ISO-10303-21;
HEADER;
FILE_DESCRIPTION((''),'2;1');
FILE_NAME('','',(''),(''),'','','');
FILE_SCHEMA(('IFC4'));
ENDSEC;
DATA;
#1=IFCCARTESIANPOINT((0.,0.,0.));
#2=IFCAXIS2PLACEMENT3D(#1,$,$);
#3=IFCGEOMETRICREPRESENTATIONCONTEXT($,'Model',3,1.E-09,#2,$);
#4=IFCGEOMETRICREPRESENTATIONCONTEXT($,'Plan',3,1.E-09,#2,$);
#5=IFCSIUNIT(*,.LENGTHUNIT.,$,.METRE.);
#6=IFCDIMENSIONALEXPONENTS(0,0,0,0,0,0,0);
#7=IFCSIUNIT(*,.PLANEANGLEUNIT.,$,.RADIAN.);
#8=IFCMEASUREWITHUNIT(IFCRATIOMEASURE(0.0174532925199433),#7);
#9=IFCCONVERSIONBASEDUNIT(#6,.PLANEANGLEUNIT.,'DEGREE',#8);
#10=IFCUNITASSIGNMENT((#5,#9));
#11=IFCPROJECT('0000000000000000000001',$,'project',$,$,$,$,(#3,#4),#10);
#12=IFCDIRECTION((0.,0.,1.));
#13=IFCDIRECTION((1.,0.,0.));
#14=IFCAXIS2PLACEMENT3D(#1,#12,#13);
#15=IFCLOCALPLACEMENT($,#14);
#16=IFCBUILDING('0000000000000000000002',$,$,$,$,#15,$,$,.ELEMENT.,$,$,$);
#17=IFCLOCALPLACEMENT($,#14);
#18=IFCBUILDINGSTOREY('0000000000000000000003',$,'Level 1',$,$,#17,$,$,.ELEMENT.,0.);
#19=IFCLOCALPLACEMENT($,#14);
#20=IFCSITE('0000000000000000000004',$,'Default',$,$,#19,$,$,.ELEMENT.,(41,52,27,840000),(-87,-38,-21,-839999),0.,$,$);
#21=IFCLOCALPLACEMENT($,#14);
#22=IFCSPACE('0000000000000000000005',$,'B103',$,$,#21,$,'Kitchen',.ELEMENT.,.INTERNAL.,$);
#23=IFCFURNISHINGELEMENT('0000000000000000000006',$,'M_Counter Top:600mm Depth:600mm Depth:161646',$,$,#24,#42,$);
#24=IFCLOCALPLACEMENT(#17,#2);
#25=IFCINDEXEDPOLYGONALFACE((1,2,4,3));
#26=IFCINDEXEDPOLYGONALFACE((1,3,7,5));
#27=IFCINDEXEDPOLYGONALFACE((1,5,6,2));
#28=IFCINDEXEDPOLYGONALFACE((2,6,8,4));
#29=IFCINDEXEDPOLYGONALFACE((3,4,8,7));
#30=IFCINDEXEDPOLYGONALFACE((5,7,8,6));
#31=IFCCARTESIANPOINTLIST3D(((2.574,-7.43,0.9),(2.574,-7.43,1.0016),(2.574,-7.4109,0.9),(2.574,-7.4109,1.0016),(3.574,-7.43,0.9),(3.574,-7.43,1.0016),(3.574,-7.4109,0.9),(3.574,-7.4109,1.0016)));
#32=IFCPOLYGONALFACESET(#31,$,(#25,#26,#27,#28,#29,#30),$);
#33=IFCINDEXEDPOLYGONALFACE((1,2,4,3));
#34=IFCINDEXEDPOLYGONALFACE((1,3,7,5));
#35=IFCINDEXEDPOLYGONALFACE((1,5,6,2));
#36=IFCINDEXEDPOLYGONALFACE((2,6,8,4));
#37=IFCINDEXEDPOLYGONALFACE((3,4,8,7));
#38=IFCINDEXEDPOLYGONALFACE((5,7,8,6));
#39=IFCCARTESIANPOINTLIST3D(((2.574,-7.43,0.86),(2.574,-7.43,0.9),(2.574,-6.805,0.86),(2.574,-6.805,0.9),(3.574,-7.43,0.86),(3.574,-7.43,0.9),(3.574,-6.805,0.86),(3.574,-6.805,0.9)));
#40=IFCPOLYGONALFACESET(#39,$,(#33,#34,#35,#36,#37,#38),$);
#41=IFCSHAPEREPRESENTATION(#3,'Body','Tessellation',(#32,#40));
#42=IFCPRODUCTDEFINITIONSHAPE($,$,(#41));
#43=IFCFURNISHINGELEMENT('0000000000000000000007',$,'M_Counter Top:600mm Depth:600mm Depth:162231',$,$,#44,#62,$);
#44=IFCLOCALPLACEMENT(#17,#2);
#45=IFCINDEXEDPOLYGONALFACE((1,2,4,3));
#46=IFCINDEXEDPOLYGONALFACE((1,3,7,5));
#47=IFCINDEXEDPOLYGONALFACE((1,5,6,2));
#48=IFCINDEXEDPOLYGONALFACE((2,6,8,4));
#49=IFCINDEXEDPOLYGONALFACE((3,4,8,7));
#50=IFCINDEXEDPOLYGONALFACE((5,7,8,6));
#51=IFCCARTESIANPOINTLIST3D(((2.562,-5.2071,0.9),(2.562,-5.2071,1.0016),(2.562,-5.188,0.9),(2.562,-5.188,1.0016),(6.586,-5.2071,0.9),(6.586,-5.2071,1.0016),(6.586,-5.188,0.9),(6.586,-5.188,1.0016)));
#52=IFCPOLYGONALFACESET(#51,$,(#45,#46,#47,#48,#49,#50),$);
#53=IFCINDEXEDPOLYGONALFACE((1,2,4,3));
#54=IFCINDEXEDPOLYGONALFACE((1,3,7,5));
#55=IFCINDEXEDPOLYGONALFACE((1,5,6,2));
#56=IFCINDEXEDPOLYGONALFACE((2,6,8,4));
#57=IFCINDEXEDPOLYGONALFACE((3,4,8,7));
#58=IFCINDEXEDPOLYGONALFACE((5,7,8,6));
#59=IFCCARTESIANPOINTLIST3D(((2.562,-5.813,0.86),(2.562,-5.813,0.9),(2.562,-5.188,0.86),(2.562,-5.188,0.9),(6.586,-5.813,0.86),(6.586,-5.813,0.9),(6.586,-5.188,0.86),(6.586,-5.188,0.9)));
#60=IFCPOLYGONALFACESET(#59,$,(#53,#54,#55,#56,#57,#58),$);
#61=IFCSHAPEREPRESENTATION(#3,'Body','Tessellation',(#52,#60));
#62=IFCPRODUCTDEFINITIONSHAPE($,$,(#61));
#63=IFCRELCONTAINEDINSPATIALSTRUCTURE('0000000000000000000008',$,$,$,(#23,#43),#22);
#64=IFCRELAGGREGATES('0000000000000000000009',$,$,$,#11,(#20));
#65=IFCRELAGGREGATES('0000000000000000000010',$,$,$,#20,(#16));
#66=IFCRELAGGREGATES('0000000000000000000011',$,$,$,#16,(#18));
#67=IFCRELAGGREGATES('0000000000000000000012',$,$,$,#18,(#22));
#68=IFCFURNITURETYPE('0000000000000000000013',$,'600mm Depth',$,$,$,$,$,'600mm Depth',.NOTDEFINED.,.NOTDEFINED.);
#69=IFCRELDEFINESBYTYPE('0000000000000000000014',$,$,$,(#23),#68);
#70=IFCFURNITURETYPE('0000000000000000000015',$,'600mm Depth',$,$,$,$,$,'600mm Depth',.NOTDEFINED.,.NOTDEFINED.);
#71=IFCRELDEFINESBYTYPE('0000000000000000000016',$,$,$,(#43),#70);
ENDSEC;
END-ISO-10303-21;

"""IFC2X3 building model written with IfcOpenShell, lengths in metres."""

from ifc_helpers import new_model, entity, si_unit, converted_unit, frame, origin, origin_with_axes, origin_2d_with_axis, place, context, project, spatial, rectangle, extrude, source, transform, mapped, type_object, type_shapes, element, save


model = new_model("IFC2X3")

# Units and contexts
model_context = context("Model", 3, precision=1e-09, world=origin())
plan_context = context("Plan", 3, precision=1e-09, world=origin())
ifc_project = project(units=[si_unit("LENGTHUNIT", "METRE"), converted_unit("PLANEANGLEUNIT", "DEGREE", entity("IfcRatioMeasure", 0.0174532925199433), si_unit("PLANEANGLEUNIT", "RADIAN"), dimensions=[0, 0, 0, 0, 0, 0, 0])], contexts=[model_context, plan_context])

# Site, building, storey, space
site_placement = place(None, origin_with_axes())
site = spatial("IfcSite", under=ifc_project, at=site_placement, Name="Default", CompositionType="ELEMENT", RefLatitude=(41, 52, 27, 840000), RefLongitude=(-87, -38, -21, -839999), RefElevation=0.0)
building_placement = place(None, origin_with_axes())
building = spatial("IfcBuilding", under=site, at=building_placement, CompositionType="ELEMENT")
storey_placement = place(None, origin_with_axes())
storey = spatial("IfcBuildingStorey", under=building, at=storey_placement, Name="Level 1", CompositionType="ELEMENT", Elevation=0.0)
space_placement = place(None, origin_with_axes())
space = spatial("IfcSpace", under=storey, at=space_placement, Name="B103", LongName="Kitchen", CompositionType="ELEMENT", InteriorOrExteriorSpace="INTERNAL")

# Furnishing elements
furniture_type_1 = type_object("IfcFurnitureType", Name="600mm Depth", ElementType="600mm Depth", AssemblyPlace="NOTDEFINED")
shared_shape_1 = source(origin(), model_context, "Body", "SweptSolid", [
    extrude(rectangle(XDim=0.0191, YDim=1.0, at=origin_2d_with_axis()), frame((-0.7005, -0.0095, 0.9), z_axis=(0.0, 0.0, 1.0), x_axis=(0.0, -1.0, 0.0)), (0.0, 0.0, 1.0), 0.1016),
    extrude(rectangle(XDim=1.0, YDim=0.625, at=origin_2d_with_axis()), frame((-0.7005, -0.3125, 0.86), z_axis=(0.0, 0.0, 1.0), x_axis=(-1.0, 0.0, 0.0)), (0.0, 0.0, 1.0), 0.04),
])
type_shapes(furniture_type_1, [shared_shape_1])
furnishing_1_placement = place(None, frame((2.3735, -7.43, 0.0), z_axis=(0.0, 0.0, 1.0), x_axis=(-1.0, 0.0, 0.0)))
element("IfcFurnishingElement", 1, at=furnishing_1_placement, inside=space, type_object=furniture_type_1, Name="M_Counter Top:600mm Depth:600mm Depth:161646", context=model_context, shape_type="MappedRepresentation", body=[
    mapped(shared_shape_1, transform((0.0, 0.0, 0.0), scale=1.0)),
])
furniture_type_2 = type_object("IfcFurnitureType", Name="600mm Depth", ElementType="600mm Depth", AssemblyPlace="NOTDEFINED")
shared_shape_2 = source(origin(), model_context, "Body", "SweptSolid", [
    extrude(rectangle(XDim=0.0191, YDim=4.024, at=origin_2d_with_axis()), frame((0.8115, -0.0095, 0.9), z_axis=(0.0, 0.0, 1.0), x_axis=(0.0, -1.0, 0.0)), (0.0, 0.0, 1.0), 0.1016),
    extrude(rectangle(XDim=4.024, YDim=0.625, at=origin_2d_with_axis()), frame((0.8115, -0.3125, 0.86), z_axis=(0.0, 0.0, 1.0), x_axis=(-1.0, 0.0, 0.0)), (0.0, 0.0, 1.0), 0.04),
])
type_shapes(furniture_type_2, [shared_shape_2])
furnishing_2_placement = place(None, frame((3.7625, -5.188, 0.0), z_axis=(0.0, 0.0, 1.0), x_axis=(1.0, 0.0, 0.0)))
element("IfcFurnishingElement", 2, at=furnishing_2_placement, inside=space, type_object=furniture_type_2, Name="M_Counter Top:600mm Depth:600mm Depth:162231", context=model_context, shape_type="MappedRepresentation", body=[
    mapped(shared_shape_2, transform((0.0, 0.0, 0.0), scale=1.0)),
])

save(model, "model.ifc")
